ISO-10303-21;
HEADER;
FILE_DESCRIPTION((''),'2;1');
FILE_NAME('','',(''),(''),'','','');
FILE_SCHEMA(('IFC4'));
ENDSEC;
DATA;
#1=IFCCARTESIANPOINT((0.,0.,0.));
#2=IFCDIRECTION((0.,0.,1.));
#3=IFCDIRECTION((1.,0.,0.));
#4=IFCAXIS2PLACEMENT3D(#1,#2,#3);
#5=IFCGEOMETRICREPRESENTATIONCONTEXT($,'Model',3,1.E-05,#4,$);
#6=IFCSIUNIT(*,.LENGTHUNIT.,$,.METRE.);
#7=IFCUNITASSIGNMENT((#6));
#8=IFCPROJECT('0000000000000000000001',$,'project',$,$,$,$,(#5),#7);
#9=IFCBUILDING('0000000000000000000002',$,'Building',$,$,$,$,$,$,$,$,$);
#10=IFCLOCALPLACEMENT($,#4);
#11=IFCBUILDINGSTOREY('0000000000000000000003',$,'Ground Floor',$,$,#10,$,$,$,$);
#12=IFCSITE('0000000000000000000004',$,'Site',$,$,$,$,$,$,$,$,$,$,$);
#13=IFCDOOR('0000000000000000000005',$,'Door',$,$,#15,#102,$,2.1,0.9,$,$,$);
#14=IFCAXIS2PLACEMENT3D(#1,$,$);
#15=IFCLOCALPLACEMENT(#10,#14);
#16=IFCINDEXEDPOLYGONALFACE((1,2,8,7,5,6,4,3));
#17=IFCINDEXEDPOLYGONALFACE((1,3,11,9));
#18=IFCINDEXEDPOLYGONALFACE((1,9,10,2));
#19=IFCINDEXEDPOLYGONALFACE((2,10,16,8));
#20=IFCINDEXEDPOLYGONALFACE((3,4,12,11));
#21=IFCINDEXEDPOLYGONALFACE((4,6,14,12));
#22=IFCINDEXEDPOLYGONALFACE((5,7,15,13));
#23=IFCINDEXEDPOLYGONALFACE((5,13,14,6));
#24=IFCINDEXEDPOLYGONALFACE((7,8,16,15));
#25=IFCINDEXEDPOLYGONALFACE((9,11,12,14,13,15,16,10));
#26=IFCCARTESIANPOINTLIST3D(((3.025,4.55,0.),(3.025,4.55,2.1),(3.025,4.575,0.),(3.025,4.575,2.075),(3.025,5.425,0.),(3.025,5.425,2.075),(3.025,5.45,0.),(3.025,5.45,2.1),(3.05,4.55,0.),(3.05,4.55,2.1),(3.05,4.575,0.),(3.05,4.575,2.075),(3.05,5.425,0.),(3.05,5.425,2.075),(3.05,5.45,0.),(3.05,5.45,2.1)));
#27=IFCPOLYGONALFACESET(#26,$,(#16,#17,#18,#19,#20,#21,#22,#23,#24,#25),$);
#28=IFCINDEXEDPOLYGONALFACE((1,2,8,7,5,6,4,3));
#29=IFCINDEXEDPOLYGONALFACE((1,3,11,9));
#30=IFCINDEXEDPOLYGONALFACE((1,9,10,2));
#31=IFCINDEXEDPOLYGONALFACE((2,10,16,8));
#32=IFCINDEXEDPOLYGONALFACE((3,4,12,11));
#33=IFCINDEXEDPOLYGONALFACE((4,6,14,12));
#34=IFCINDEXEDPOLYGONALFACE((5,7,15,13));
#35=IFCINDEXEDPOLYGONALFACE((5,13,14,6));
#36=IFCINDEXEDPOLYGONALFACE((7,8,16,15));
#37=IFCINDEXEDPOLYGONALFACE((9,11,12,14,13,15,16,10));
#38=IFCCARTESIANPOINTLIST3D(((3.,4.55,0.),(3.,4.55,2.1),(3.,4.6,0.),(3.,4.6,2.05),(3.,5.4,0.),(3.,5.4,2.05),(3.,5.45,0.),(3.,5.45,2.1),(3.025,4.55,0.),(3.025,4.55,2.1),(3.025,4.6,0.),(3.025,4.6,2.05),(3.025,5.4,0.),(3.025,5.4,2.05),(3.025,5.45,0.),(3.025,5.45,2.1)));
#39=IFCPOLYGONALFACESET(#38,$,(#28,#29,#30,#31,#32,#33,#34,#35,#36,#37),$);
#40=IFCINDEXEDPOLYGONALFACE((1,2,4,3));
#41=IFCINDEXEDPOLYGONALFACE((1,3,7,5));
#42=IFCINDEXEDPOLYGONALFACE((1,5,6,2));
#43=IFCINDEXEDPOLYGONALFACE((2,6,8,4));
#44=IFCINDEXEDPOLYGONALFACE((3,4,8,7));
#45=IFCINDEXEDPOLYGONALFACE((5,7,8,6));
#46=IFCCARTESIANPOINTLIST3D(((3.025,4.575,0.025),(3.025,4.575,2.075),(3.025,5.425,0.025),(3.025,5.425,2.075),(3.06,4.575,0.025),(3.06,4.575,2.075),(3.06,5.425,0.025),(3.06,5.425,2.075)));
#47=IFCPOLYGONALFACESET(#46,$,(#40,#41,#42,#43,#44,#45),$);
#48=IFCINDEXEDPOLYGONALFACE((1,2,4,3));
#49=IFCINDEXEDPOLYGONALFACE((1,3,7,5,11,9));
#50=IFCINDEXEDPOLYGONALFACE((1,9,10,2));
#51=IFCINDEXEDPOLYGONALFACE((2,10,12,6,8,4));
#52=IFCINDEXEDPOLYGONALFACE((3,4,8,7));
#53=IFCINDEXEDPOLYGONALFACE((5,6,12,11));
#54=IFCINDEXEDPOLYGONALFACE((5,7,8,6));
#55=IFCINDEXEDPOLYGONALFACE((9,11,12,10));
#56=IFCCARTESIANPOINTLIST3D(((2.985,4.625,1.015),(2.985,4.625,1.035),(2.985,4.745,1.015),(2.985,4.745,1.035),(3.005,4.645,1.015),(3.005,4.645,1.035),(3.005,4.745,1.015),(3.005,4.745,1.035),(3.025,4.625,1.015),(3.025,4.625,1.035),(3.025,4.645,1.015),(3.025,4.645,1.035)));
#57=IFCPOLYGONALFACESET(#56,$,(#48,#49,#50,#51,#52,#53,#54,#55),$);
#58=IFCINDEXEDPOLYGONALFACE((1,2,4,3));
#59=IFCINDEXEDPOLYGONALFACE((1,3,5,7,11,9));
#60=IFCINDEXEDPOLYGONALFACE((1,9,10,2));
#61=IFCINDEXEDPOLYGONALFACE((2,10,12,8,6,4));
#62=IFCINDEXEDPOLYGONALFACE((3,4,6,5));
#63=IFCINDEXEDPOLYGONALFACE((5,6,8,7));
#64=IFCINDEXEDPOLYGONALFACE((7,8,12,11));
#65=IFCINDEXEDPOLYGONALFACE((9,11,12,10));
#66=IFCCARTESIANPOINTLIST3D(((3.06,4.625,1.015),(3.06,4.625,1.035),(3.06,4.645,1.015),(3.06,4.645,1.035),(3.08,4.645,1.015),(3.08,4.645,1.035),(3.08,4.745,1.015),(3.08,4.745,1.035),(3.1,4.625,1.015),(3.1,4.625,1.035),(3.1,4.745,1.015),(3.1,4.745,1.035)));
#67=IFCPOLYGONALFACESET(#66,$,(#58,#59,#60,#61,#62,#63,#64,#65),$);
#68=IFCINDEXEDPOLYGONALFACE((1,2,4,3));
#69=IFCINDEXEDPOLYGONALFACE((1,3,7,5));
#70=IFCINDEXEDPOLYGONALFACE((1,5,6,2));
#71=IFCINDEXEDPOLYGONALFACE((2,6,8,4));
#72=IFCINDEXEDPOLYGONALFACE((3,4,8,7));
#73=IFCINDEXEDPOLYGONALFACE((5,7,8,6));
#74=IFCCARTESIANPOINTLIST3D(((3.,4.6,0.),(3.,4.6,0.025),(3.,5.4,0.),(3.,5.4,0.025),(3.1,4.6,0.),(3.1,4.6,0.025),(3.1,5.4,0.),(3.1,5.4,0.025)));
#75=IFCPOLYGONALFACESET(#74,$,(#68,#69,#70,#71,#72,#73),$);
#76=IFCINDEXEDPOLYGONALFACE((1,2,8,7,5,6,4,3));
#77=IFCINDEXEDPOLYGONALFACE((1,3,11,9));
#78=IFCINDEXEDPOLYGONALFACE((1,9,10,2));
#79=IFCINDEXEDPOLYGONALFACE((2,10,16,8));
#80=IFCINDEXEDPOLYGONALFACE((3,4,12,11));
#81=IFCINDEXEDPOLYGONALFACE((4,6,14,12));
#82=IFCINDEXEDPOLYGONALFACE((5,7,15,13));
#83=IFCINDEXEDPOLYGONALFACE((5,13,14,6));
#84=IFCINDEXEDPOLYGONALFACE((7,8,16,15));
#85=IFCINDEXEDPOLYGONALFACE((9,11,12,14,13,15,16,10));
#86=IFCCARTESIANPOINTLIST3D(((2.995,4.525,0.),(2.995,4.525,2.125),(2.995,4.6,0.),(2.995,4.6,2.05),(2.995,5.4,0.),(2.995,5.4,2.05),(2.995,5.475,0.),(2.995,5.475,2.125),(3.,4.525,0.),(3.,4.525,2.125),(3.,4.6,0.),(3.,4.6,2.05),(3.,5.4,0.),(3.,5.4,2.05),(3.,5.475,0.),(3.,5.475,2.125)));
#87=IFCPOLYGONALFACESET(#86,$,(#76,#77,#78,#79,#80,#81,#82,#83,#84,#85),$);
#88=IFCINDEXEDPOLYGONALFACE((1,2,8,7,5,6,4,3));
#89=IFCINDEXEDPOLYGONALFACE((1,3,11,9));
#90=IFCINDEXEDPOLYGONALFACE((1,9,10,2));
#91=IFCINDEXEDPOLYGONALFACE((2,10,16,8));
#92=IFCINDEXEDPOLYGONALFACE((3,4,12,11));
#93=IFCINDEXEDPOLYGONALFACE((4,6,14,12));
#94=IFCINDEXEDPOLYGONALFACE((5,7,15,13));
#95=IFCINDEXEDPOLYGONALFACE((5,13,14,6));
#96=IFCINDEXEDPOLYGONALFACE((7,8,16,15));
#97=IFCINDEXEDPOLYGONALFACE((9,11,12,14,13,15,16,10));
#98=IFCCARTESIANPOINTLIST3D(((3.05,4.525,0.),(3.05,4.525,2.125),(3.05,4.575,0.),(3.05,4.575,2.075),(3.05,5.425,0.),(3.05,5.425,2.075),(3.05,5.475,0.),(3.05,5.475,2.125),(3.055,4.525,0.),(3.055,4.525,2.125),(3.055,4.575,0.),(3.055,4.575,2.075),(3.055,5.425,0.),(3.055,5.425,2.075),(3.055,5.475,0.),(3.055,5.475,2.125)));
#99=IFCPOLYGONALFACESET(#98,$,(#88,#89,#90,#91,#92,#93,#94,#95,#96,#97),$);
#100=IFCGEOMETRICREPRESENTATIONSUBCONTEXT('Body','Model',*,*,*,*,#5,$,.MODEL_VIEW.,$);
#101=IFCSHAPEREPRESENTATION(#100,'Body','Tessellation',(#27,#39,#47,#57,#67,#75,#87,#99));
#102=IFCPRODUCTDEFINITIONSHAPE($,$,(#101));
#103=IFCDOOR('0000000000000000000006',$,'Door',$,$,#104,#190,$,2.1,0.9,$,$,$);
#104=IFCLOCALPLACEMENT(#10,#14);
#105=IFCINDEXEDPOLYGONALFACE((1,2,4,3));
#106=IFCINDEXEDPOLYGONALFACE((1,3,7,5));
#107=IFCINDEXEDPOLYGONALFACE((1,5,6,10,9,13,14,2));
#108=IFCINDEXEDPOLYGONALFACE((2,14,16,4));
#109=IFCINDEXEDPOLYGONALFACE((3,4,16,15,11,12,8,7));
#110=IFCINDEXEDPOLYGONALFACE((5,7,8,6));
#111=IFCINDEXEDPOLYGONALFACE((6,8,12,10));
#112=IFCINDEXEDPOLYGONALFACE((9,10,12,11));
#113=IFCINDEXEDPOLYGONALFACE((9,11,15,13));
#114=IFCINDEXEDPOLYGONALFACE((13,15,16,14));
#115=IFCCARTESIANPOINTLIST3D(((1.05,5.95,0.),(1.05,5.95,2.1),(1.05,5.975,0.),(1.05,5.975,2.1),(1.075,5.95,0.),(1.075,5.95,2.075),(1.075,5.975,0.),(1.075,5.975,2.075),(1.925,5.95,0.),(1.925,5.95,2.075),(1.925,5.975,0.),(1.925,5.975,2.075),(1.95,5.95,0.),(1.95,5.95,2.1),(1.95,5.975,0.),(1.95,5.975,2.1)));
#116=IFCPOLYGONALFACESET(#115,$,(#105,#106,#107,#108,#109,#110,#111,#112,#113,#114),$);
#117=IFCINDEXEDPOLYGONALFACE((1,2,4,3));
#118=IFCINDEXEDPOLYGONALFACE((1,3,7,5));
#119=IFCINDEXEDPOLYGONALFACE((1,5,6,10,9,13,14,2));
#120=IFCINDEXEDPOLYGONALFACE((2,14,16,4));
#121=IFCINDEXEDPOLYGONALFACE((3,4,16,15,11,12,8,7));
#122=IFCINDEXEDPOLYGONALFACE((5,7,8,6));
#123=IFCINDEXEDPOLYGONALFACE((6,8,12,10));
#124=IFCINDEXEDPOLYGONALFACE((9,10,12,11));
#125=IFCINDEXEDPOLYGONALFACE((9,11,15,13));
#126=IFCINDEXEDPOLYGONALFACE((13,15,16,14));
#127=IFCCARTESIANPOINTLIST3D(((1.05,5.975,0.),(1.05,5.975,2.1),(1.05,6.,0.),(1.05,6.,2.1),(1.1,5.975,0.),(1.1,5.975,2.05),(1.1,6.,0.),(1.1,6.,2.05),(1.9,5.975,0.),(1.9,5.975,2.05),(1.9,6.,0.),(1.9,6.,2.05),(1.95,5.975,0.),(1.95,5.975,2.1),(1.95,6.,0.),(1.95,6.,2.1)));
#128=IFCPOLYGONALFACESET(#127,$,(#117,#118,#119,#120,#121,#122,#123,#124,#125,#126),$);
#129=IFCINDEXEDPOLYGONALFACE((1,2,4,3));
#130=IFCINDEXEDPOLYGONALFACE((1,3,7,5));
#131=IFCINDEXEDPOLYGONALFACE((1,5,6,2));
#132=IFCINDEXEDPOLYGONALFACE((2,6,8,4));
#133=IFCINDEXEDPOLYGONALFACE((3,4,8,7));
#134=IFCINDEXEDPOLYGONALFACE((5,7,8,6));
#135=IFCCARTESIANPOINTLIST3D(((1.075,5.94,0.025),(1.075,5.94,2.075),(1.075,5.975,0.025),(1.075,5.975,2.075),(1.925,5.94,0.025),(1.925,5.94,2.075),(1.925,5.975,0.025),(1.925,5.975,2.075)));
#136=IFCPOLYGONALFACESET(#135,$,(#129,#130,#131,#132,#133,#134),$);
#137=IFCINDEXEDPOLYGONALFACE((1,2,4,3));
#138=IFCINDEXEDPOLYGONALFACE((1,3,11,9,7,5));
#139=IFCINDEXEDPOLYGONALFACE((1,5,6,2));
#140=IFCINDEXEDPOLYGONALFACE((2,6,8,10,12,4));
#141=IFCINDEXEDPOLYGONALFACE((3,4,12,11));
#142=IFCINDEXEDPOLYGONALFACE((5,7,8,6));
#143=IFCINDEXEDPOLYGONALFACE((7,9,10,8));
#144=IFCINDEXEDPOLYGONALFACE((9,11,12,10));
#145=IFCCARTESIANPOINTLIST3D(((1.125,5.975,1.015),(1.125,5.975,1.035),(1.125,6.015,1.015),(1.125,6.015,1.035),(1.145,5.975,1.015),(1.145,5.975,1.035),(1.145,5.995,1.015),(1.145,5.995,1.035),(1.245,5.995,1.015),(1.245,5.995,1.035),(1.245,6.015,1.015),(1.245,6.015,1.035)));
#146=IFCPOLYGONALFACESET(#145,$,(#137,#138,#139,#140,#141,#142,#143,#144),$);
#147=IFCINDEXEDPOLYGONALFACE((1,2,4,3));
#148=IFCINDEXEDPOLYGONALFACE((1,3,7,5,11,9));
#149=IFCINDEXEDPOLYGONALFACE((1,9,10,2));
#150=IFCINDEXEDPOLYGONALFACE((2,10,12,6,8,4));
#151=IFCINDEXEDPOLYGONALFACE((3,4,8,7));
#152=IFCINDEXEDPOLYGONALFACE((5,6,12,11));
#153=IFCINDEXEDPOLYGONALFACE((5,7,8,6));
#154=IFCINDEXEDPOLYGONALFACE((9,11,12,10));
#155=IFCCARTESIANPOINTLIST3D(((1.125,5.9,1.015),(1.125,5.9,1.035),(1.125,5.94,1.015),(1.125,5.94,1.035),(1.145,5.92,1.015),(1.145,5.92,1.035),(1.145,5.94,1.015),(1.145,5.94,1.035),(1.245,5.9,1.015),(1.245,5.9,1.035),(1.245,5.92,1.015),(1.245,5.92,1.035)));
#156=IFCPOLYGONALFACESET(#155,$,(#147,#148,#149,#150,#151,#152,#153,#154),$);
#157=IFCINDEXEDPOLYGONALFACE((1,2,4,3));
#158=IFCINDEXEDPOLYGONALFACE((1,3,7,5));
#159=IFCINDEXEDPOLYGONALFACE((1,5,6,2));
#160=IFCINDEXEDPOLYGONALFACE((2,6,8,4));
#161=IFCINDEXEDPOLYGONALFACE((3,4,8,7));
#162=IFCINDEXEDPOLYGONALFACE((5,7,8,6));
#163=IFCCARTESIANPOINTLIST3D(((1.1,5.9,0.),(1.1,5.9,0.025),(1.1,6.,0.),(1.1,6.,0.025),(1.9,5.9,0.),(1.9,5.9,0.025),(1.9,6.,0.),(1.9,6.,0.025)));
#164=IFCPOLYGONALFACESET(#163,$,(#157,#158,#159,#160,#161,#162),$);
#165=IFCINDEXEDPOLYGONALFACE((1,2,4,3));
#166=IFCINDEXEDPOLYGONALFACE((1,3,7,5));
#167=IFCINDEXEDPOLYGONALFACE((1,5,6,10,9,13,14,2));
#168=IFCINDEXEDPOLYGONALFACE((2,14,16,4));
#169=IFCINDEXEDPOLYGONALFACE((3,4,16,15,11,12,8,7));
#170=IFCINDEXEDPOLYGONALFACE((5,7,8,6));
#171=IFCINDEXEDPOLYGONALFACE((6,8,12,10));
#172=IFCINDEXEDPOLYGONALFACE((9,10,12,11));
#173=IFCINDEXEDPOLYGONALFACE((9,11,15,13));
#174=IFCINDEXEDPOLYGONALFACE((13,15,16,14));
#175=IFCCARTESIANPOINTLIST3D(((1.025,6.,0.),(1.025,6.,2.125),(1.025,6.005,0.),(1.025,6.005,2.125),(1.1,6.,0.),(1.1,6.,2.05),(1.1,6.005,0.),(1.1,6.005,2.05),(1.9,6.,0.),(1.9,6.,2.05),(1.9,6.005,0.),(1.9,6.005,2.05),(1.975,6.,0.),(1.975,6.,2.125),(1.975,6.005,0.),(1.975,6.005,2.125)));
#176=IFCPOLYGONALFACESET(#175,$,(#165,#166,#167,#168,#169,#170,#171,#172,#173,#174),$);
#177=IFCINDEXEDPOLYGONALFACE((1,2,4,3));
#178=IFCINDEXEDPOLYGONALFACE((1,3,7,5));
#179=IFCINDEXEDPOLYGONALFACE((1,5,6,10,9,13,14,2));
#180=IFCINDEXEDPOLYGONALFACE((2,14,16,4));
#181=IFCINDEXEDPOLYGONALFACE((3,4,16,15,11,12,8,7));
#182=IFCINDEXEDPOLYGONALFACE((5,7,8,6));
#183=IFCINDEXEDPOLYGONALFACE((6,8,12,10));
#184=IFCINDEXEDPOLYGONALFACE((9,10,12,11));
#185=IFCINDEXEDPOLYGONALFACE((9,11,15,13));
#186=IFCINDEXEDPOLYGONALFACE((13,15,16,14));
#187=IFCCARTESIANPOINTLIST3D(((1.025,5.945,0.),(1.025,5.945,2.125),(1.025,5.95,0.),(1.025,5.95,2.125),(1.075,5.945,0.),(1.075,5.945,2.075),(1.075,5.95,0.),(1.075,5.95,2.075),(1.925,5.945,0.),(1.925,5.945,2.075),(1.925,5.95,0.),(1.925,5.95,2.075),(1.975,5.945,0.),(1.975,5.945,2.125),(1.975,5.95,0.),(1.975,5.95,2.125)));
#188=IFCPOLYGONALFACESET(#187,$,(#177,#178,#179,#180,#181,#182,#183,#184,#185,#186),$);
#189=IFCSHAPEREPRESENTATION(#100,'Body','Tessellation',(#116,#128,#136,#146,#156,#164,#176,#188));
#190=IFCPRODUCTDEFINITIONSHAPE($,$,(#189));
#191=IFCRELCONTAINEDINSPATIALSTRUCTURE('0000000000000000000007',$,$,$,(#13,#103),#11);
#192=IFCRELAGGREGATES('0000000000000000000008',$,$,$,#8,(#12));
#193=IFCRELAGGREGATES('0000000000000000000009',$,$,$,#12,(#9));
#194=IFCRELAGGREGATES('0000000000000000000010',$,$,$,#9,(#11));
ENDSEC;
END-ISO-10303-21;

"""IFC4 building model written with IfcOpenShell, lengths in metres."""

from ifc_helpers import new_model, si_unit, frame, origin_with_axes, place, context, subcontext, project, spatial, line, indexed_curve, outline, extrude, element, save


model = new_model("IFC4")

# Units and contexts
model_context = context("Model", 3, precision=1e-05, world=origin_with_axes())
body_context = subcontext(model_context, "Body", "Model", "MODEL_VIEW")
ifc_project = project(units=[si_unit("LENGTHUNIT", "METRE")], contexts=[model_context])

# Site, building, storey
site = spatial("IfcSite", under=ifc_project, Name="Site")
building = spatial("IfcBuilding", under=site, Name="Building")
storey_placement = place(None, origin_with_axes())
storey = spatial("IfcBuildingStorey", under=building, at=storey_placement, Name="Ground Floor")

# Doors
door_1_placement = place(storey_placement, frame((3.0, 5.45, 0.0), z_axis=(0.0, 0.0, 1.0), x_axis=(0.0, -1.0, 0.0)))
element("IfcDoor", 1, at=door_1_placement, inside=storey, Name="Door", OverallHeight=2.1, OverallWidth=0.9, context=body_context, shape_type="SweptSolid", body=[
    extrude(outline(indexed_curve([(0.0, 0.0), (0.0, 2.1), (0.9, 2.1), (0.9, 0.0), (0.875, 0.0), (0.875, 2.075), (0.025, 2.075), (0.025, 0.0)], segments=[line(1, 2, 3, 4, 5, 6, 7, 8, 1)])), frame((0.0, 0.025, 0.0), z_axis=(0.0, -1.0, 0.0), x_axis=(1.0, 0.0, 0.0)), (0.0, 0.0, -1.0), 0.025),
    extrude(outline(indexed_curve([(0.0, 0.0), (0.0, 2.1), (0.9, 2.1), (0.9, 0.0), (0.85, 0.0), (0.85, 2.05), (0.05, 2.05), (0.05, 0.0)], segments=[line(1, 2, 3, 4, 5, 6, 7, 8, 1)])), frame((0.0, 0.0, 0.0), z_axis=(0.0, -1.0, 0.0), x_axis=(1.0, 0.0, 0.0)), (0.0, 0.0, -1.0), 0.025),
    extrude(outline(indexed_curve([(0.0, 0.0), (0.85, 0.0), (0.85, 0.035), (0.0, 0.035)], segments=[line(1, 2, 3, 4, 1)])), frame((0.025, 0.025, 0.025), z_axis=(0.0, 0.0, 1.0), x_axis=(1.0, 0.0, 0.0)), (0.0, 0.0, 1.0), 2.05),
    extrude(outline(indexed_curve([(0.0, 0.0), (0.0, -0.04), (-0.12, -0.04), (-0.12, -0.02), (-0.02, -0.02), (-0.02, 0.0)], segments=[line(1, 2, 3, 4, 5, 6, 1)])), frame((0.825, 0.025, 1.015), z_axis=(0.0, 0.0, 1.0), x_axis=(1.0, 0.0, 0.0)), (0.0, 0.0, 1.0), 0.02),
    extrude(outline(indexed_curve([(0.0, 0.0), (0.0, 0.04), (-0.12, 0.04), (-0.12, 0.02), (-0.02, 0.02), (-0.02, 0.0)], segments=[line(1, 2, 3, 4, 5, 6, 1)])), frame((0.825, 0.06, 1.015), z_axis=(0.0, 0.0, 1.0), x_axis=(1.0, 0.0, 0.0)), (0.0, 0.0, 1.0), 0.02),
    extrude(outline(indexed_curve([(0.0, 0.0), (0.8, 0.0), (0.8, 0.1), (0.0, 0.1)], segments=[line(1, 2, 3, 4, 1)])), frame((0.05, 0.0, 0.0), z_axis=(0.0, 0.0, 1.0), x_axis=(1.0, 0.0, 0.0)), (0.0, 0.0, 1.0), 0.025),
    extrude(outline(indexed_curve([(0.0, 0.0), (0.0, 2.125), (0.95, 2.125), (0.95, 0.0), (0.875, 0.0), (0.875, 2.05), (0.075, 2.05), (0.075, 0.0)], segments=[line(1, 2, 3, 4, 5, 6, 7, 8, 1)])), frame((-0.025, -0.005, 0.0), z_axis=(0.0, -1.0, 0.0), x_axis=(1.0, 0.0, 0.0)), (0.0, 0.0, -1.0), 0.005),
    extrude(outline(indexed_curve([(0.0, 0.0), (0.0, 2.125), (0.95, 2.125), (0.95, 0.0), (0.9, 0.0), (0.9, 2.075), (0.05, 2.075), (0.05, 0.0)], segments=[line(1, 2, 3, 4, 5, 6, 7, 8, 1)])), frame((-0.025, 0.05, 0.0), z_axis=(0.0, -1.0, 0.0), x_axis=(1.0, 0.0, 0.0)), (0.0, 0.0, -1.0), 0.005),
])
door_2_placement = place(storey_placement, frame((1.95, 6.0, 0.0), z_axis=(0.0, 0.0, 1.0), x_axis=(-1.0, 0.0, 0.0)))
element("IfcDoor", 2, at=door_2_placement, inside=storey, Name="Door", OverallHeight=2.1, OverallWidth=0.9, context=body_context, shape_type="SweptSolid", body=[
    extrude(outline(indexed_curve([(0.0, 0.0), (0.0, 2.1), (0.9, 2.1), (0.9, 0.0), (0.875, 0.0), (0.875, 2.075), (0.025, 2.075), (0.025, 0.0)], segments=[line(1, 2, 3, 4, 5, 6, 7, 8, 1)])), frame((0.0, 0.025, 0.0), z_axis=(0.0, -1.0, 0.0), x_axis=(1.0, 0.0, 0.0)), (0.0, 0.0, -1.0), 0.025),
    extrude(outline(indexed_curve([(0.0, 0.0), (0.0, 2.1), (0.9, 2.1), (0.9, 0.0), (0.85, 0.0), (0.85, 2.05), (0.05, 2.05), (0.05, 0.0)], segments=[line(1, 2, 3, 4, 5, 6, 7, 8, 1)])), frame((0.0, 0.0, 0.0), z_axis=(0.0, -1.0, 0.0), x_axis=(1.0, 0.0, 0.0)), (0.0, 0.0, -1.0), 0.025),
    extrude(outline(indexed_curve([(0.0, 0.0), (0.85, 0.0), (0.85, 0.035), (0.0, 0.035)], segments=[line(1, 2, 3, 4, 1)])), frame((0.025, 0.025, 0.025), z_axis=(0.0, 0.0, 1.0), x_axis=(1.0, 0.0, 0.0)), (0.0, 0.0, 1.0), 2.05),
    extrude(outline(indexed_curve([(0.0, 0.0), (0.0, -0.04), (-0.12, -0.04), (-0.12, -0.02), (-0.02, -0.02), (-0.02, 0.0)], segments=[line(1, 2, 3, 4, 5, 6, 1)])), frame((0.825, 0.025, 1.015), z_axis=(0.0, 0.0, 1.0), x_axis=(1.0, 0.0, 0.0)), (0.0, 0.0, 1.0), 0.02),
    extrude(outline(indexed_curve([(0.0, 0.0), (0.0, 0.04), (-0.12, 0.04), (-0.12, 0.02), (-0.02, 0.02), (-0.02, 0.0)], segments=[line(1, 2, 3, 4, 5, 6, 1)])), frame((0.825, 0.06, 1.015), z_axis=(0.0, 0.0, 1.0), x_axis=(1.0, 0.0, 0.0)), (0.0, 0.0, 1.0), 0.02),
    extrude(outline(indexed_curve([(0.0, 0.0), (0.8, 0.0), (0.8, 0.1), (0.0, 0.1)], segments=[line(1, 2, 3, 4, 1)])), frame((0.05, 0.0, 0.0), z_axis=(0.0, 0.0, 1.0), x_axis=(1.0, 0.0, 0.0)), (0.0, 0.0, 1.0), 0.025),
    extrude(outline(indexed_curve([(0.0, 0.0), (0.0, 2.125), (0.95, 2.125), (0.95, 0.0), (0.875, 0.0), (0.875, 2.05), (0.075, 2.05), (0.075, 0.0)], segments=[line(1, 2, 3, 4, 5, 6, 7, 8, 1)])), frame((-0.025, -0.005, 0.0), z_axis=(0.0, -1.0, 0.0), x_axis=(1.0, 0.0, 0.0)), (0.0, 0.0, -1.0), 0.005),
    extrude(outline(indexed_curve([(0.0, 0.0), (0.0, 2.125), (0.95, 2.125), (0.95, 0.0), (0.9, 0.0), (0.9, 2.075), (0.05, 2.075), (0.05, 0.0)], segments=[line(1, 2, 3, 4, 5, 6, 7, 8, 1)])), frame((-0.025, 0.05, 0.0), z_axis=(0.0, -1.0, 0.0), x_axis=(1.0, 0.0, 0.0)), (0.0, 0.0, -1.0), 0.005),
])

save(model, "model.ifc")
